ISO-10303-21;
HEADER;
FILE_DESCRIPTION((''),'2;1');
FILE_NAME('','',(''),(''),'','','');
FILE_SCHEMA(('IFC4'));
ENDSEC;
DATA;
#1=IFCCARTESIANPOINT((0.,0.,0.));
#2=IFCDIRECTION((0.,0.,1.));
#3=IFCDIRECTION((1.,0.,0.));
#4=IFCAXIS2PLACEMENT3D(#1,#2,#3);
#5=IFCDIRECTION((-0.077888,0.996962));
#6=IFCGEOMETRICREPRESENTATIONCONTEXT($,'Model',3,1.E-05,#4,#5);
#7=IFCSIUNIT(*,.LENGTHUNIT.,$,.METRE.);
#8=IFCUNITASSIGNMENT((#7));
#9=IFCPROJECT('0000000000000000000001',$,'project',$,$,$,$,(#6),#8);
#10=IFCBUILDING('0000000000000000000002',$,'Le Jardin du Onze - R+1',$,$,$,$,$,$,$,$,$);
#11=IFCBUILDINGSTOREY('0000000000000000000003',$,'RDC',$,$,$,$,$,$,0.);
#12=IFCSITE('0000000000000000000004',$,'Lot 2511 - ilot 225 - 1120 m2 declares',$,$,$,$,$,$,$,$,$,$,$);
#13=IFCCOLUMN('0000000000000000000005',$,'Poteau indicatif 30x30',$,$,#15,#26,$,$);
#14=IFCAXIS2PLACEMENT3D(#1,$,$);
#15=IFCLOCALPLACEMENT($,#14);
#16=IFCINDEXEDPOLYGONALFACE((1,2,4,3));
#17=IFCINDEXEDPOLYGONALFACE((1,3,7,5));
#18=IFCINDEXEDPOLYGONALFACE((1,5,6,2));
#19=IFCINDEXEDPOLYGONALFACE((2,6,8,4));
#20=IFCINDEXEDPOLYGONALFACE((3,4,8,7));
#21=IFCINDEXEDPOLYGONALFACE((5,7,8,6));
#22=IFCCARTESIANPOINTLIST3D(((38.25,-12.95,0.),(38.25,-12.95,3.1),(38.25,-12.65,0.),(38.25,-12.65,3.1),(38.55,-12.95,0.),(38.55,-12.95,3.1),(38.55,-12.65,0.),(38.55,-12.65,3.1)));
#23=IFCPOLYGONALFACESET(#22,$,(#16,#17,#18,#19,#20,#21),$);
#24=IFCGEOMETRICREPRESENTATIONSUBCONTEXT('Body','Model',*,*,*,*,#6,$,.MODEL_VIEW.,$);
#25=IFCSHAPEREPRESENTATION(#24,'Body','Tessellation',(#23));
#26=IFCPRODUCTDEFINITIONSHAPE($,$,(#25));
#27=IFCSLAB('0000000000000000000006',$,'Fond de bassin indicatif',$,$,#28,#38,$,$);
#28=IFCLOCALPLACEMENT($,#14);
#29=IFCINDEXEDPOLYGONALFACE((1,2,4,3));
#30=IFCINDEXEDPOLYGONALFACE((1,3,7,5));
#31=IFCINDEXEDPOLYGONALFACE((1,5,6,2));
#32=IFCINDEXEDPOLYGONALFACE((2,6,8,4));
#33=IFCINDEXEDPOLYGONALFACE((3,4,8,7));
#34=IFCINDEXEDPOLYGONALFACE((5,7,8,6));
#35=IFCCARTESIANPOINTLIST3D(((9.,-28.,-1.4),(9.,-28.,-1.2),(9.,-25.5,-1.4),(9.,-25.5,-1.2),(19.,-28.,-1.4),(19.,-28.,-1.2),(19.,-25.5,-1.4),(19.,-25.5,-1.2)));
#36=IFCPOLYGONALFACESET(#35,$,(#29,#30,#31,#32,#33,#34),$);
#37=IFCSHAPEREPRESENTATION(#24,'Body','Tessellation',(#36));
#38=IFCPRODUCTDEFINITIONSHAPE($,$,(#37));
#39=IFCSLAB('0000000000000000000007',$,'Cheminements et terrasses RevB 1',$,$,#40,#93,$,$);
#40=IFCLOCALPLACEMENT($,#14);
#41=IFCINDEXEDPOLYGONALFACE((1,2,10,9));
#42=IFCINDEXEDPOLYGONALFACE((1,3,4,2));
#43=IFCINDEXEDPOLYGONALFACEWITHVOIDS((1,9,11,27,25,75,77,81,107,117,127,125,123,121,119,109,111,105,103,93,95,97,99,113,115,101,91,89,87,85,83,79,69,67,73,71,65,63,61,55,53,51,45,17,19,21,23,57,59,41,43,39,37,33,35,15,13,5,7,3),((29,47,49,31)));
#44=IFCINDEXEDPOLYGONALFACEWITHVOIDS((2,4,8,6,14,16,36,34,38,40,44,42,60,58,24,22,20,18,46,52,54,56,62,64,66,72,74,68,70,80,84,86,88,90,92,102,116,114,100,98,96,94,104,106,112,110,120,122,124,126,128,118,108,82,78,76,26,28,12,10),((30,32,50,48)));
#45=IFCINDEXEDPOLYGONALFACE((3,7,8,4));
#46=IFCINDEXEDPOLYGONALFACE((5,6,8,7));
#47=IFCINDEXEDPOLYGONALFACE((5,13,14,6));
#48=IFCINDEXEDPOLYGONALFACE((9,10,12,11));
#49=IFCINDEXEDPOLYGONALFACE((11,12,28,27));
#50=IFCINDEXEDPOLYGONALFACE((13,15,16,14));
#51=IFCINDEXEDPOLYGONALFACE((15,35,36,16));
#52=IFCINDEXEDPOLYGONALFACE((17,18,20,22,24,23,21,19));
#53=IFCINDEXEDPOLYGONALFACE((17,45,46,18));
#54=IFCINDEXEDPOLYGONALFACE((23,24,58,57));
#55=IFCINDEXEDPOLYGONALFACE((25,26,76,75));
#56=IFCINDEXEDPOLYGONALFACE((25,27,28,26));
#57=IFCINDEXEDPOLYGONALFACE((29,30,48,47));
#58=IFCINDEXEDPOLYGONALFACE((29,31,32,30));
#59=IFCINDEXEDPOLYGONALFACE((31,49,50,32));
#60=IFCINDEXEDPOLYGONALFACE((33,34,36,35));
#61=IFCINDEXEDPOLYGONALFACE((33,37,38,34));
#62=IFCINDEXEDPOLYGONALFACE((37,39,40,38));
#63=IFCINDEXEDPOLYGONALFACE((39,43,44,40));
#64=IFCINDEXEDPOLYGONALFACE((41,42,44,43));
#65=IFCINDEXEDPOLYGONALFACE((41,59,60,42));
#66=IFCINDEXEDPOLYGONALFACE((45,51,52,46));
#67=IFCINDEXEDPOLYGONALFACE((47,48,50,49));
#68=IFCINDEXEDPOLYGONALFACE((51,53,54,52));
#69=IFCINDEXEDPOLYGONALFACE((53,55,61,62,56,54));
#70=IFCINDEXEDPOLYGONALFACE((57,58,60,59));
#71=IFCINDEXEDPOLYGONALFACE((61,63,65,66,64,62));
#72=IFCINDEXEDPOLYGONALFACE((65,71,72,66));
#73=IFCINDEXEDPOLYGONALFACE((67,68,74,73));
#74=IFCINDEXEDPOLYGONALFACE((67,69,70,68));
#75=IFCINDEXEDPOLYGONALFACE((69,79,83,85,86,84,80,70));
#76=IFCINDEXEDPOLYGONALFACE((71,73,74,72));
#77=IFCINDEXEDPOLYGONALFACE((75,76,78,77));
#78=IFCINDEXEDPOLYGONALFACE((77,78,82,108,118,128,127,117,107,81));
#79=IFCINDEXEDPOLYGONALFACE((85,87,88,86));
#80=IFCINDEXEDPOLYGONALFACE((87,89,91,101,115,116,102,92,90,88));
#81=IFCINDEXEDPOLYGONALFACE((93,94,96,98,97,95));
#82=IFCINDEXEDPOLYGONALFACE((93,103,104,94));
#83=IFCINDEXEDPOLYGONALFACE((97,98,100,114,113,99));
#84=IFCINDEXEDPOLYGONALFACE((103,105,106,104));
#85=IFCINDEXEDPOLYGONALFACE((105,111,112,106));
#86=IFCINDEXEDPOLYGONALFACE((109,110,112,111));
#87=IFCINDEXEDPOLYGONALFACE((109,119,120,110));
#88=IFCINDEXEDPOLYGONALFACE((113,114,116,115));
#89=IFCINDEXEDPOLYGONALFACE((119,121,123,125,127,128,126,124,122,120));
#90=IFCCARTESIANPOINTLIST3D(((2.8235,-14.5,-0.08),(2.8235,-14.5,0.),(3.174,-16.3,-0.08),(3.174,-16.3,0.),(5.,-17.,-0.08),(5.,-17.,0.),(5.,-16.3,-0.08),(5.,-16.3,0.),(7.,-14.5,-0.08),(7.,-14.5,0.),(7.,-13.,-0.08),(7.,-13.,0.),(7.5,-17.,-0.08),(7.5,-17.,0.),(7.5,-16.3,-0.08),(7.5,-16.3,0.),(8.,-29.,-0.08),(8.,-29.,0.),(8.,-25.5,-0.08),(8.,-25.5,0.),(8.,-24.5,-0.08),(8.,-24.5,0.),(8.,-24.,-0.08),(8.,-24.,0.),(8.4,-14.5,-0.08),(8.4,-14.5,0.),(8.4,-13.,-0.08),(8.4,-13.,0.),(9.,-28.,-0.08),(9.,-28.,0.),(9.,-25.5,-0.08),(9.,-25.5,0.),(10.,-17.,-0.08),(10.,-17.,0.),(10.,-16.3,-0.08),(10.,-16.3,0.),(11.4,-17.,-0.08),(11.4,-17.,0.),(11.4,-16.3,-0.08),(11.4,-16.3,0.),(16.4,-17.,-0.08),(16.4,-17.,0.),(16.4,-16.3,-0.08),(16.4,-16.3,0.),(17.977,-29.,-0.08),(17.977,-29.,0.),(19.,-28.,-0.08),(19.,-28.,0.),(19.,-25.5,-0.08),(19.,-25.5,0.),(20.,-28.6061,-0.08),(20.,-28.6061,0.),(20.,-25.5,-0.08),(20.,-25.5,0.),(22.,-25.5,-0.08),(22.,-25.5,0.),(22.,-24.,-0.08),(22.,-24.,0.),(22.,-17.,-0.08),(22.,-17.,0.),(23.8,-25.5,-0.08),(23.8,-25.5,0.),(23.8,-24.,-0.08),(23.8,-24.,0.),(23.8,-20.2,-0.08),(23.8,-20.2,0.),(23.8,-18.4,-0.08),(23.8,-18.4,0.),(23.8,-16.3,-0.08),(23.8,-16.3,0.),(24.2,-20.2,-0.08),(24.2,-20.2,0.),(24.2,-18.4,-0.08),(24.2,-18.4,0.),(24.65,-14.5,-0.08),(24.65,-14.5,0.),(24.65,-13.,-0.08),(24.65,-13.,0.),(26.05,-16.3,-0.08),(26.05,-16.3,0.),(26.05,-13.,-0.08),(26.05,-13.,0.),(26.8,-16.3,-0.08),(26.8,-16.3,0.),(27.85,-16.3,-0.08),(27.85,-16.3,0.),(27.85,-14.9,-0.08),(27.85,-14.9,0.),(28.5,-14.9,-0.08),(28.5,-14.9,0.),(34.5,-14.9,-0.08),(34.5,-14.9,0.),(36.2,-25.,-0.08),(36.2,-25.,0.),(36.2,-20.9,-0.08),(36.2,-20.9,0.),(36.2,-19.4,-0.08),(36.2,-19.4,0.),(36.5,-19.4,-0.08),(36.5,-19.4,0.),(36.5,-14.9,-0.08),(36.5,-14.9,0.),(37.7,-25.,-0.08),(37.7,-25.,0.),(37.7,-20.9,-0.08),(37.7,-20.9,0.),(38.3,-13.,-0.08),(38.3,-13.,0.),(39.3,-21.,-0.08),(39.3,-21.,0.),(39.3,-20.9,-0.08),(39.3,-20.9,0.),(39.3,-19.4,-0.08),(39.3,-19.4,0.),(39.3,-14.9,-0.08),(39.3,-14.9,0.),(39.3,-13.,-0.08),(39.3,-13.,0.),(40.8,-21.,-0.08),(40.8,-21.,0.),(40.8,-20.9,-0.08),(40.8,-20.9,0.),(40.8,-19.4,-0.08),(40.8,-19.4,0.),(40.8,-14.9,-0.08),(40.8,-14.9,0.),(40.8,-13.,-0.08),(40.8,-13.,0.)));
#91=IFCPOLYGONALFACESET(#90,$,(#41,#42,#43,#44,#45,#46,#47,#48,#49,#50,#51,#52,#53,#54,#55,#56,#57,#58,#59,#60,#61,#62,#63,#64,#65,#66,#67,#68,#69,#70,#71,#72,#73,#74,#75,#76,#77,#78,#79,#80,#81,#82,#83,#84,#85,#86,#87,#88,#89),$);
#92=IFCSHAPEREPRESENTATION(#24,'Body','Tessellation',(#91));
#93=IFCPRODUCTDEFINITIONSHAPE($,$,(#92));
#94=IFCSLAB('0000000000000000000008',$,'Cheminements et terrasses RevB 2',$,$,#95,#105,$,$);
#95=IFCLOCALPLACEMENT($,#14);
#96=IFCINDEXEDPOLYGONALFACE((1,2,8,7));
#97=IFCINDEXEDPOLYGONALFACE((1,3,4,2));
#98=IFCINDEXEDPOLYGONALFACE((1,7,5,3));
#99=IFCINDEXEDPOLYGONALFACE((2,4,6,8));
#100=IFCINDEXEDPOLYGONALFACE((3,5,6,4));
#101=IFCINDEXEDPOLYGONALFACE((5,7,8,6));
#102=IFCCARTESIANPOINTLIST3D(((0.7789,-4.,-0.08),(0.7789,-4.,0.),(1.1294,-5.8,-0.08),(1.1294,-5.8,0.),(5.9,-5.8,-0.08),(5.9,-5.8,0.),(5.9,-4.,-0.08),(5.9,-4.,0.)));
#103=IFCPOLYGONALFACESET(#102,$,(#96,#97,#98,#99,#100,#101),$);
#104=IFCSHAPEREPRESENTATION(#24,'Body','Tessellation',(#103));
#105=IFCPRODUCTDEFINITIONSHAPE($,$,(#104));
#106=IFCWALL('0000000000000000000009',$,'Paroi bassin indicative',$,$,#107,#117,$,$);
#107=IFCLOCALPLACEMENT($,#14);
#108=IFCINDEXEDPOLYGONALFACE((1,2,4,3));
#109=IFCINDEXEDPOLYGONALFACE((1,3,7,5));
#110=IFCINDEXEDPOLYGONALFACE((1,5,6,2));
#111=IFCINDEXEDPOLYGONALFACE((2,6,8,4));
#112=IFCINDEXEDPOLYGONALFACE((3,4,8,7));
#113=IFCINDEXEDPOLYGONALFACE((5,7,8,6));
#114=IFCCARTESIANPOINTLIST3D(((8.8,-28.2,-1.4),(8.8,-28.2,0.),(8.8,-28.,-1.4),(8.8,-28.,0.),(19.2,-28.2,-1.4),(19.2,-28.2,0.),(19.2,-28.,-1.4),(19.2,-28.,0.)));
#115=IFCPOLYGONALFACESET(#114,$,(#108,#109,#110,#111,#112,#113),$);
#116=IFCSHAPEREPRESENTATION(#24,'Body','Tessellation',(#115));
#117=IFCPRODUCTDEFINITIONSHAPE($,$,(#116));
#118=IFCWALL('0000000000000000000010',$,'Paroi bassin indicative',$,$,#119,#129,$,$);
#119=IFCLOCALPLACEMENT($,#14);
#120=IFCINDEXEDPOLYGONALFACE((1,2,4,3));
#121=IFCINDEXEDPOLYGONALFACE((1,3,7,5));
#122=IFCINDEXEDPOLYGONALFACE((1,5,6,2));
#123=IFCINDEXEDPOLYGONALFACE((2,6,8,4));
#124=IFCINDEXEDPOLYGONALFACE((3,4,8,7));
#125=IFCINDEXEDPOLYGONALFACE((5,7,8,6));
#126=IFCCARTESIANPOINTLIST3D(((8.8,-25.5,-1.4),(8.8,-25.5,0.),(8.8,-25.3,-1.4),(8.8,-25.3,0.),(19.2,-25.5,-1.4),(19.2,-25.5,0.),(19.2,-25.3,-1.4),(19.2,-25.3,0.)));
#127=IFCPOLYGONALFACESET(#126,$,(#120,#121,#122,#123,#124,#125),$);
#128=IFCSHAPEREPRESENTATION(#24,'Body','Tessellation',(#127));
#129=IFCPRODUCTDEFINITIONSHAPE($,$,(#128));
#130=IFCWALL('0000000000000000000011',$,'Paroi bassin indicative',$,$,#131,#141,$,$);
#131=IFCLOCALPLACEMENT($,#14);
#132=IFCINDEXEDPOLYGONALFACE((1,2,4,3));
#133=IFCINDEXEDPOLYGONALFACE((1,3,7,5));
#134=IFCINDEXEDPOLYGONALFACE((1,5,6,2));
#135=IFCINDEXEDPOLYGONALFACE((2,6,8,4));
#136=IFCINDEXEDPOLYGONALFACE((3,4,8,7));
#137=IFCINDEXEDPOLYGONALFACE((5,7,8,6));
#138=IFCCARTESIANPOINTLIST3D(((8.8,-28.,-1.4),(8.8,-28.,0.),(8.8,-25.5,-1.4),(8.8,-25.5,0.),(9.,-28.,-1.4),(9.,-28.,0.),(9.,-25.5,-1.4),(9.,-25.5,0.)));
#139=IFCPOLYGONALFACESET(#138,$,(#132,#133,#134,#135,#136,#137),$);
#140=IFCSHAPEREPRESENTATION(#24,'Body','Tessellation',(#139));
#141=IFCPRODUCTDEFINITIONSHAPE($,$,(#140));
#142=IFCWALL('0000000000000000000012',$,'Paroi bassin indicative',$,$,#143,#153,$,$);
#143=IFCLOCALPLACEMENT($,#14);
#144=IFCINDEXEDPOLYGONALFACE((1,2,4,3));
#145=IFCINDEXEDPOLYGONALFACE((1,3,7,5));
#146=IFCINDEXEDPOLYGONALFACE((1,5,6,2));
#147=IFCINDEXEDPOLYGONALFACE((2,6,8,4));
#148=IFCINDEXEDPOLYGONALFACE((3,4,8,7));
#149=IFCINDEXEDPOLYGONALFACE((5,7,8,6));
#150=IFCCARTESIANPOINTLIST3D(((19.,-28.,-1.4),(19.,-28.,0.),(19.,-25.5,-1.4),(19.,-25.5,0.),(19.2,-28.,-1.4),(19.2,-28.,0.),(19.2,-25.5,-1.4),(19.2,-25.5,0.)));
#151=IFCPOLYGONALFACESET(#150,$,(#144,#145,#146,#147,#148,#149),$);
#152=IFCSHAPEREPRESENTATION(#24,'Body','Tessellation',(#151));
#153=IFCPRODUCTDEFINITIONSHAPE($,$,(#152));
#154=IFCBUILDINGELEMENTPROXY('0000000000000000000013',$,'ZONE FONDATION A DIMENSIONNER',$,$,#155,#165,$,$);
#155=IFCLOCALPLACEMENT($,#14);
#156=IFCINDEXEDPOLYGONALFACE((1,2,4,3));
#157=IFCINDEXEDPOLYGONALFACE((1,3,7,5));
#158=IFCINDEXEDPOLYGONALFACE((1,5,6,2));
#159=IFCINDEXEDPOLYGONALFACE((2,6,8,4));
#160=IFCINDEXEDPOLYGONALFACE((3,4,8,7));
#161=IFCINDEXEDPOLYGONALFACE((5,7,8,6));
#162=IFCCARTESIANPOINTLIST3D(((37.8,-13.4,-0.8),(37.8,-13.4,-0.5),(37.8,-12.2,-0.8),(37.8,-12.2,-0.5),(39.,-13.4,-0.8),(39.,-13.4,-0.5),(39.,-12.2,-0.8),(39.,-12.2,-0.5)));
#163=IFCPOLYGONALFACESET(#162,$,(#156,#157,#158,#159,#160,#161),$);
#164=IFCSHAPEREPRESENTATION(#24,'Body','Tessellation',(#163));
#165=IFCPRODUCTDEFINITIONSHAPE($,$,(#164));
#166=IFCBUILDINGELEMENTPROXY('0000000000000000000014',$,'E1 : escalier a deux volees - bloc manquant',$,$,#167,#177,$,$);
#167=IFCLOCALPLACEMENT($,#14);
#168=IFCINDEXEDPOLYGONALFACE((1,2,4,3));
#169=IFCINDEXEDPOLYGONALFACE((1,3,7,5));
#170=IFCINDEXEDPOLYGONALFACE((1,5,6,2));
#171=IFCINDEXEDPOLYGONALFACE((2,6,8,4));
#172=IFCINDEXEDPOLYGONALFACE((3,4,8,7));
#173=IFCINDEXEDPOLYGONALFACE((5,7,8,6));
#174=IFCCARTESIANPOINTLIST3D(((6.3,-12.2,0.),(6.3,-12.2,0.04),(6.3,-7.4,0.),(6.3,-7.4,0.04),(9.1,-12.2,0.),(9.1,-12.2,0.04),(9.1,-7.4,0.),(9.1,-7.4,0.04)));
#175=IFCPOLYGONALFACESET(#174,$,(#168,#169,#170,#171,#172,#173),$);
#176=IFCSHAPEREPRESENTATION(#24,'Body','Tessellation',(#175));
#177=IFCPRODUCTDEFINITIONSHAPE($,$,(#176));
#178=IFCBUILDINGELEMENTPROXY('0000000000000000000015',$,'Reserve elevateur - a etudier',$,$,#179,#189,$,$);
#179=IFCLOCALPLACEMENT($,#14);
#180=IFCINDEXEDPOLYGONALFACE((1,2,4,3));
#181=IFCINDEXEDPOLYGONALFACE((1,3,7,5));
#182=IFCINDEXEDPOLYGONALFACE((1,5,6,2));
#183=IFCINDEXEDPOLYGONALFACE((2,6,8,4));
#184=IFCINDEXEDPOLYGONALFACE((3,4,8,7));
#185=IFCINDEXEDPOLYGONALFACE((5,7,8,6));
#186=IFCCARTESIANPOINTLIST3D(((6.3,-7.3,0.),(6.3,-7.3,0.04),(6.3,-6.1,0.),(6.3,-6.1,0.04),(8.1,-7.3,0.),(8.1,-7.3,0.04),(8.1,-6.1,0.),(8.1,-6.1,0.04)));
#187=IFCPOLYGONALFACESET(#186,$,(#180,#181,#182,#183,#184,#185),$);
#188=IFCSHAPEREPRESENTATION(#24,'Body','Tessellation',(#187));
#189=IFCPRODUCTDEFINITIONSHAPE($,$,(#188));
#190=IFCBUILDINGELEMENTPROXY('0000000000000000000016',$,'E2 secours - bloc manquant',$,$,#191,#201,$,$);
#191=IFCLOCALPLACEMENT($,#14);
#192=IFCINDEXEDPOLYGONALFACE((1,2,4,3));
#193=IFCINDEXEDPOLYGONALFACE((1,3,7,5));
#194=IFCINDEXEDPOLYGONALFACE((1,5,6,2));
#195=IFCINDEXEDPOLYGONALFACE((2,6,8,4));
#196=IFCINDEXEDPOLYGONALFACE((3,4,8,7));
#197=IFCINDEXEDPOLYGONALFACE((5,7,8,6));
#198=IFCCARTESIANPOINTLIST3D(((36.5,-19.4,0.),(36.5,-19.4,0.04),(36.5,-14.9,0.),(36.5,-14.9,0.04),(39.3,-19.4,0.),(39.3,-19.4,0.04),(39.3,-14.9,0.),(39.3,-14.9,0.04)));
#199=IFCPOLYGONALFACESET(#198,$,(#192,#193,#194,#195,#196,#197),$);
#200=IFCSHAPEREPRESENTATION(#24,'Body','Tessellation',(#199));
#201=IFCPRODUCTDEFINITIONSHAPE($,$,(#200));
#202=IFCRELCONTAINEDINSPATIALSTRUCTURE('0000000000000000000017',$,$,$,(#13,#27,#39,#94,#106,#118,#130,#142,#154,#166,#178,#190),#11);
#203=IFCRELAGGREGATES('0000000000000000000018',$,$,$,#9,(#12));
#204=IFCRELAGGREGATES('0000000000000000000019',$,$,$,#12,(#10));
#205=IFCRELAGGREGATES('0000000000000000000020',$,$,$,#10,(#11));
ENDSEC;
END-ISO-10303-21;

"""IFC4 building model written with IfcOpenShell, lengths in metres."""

from ifc_helpers import new_model, si_unit, direction, frame, origin, origin_with_axes, place, context, subcontext, project, spatial, polyline, outline, extrude, element, save


model = new_model("IFC4")

# Units and contexts
model_context = context("Model", 3, precision=1e-05, world=origin_with_axes(), true_north=direction((-0.077888, 0.996962)))
body_context = subcontext(model_context, "Body", "Model", "MODEL_VIEW")
ifc_project = project(units=[si_unit("LENGTHUNIT", "METRE")], contexts=[model_context])

# Site, building, storey
site = spatial("IfcSite", under=ifc_project, Name="Lot 2511 - ilot 225 - 1120 m2 declares")
building = spatial("IfcBuilding", under=site, Name="Le Jardin du Onze - R+1")
storey = spatial("IfcBuildingStorey", under=building, Name="RDC", Elevation=0.0)

# Column
column_placement = place(None, origin_with_axes())
element("IfcColumn", 1, at=column_placement, inside=storey, Name="Poteau indicatif 30x30", context=body_context, shape_type="SweptSolid", body=[
    extrude(outline(polyline([(38.55, -12.95), (38.55, -12.65), (38.25, -12.65), (38.25, -12.95), (38.55, -12.95)])), origin(), (0.0, 0.0, 1.0), 3.1),
])

# Slabs
slab_1_placement = place(None, origin_with_axes())
element("IfcSlab", 2, at=slab_1_placement, inside=storey, Name="Fond de bassin indicatif", context=body_context, shape_type="SweptSolid", body=[
    extrude(outline(polyline([(19.0, -28.0), (19.0, -25.5), (9.0, -25.5), (9.0, -28.0), (19.0, -28.0)])), frame((0.0, 0.0, -1.4)), (0.0, 0.0, 1.0), 0.2),
])
slab_2_placement = place(None, origin_with_axes())
element("IfcSlab", 3, at=slab_2_placement, inside=storey, Name="Cheminements et terrasses RevB 1", context=body_context, shape_type="SweptSolid", body=[
    extrude(outline(polyline([(8.0, -29.0), (8.0, -25.5), (8.0, -24.5), (8.0, -24.0), (22.0, -24.0), (22.0, -17.0), (16.4, -17.0), (16.4, -16.3), (11.4, -16.3), (11.4, -17.0), (10.0, -17.0), (10.0, -16.3), (7.5, -16.3), (7.5, -17.0), (5.0, -17.0), (5.0, -16.3), (3.174, -16.3), (2.8235, -14.5), (7.0, -14.5), (7.0, -13.0), (8.4, -13.0), (8.4, -14.5), (24.65, -14.5), (24.65, -13.0), (26.05, -13.0), (26.05, -14.5), (26.05, -14.5), (26.05, -13.0), (38.3, -13.0), (39.3, -13.0), (40.8, -13.0), (40.8, -14.9), (40.8, -19.4), (40.8, -19.4), (40.8, -20.9), (40.8, -20.9), (40.8, -21.0), (39.3, -21.0), (39.3, -20.9), (37.7, -20.9), (37.7, -25.0), (36.2, -25.0), (36.2, -20.9), (36.2, -19.4), (36.5, -19.4), (39.3, -19.4), (39.3, -14.9), (36.5, -14.9), (34.5, -14.9), (28.5, -14.9), (27.85, -14.9), (27.85, -16.3), (26.8, -16.3), (26.05, -16.3), (23.8, -16.3), (23.8, -18.4), (24.2, -18.4), (24.2, -20.2), (23.8, -20.2), (23.8, -24.0), (23.8, -25.5), (22.0, -25.5), (20.0, -25.5), (20.0, -28.6061), (17.977, -29.0), (8.0, -29.0)]), holes=[polyline([(9.0, -25.5), (9.0, -28.0), (19.0, -28.0), (19.0, -25.5), (9.0, -25.5)])]), frame((0.0, 0.0, -0.08)), (0.0, 0.0, 1.0), 0.08),
])
slab_3_placement = place(None, origin_with_axes())
element("IfcSlab", 4, at=slab_3_placement, inside=storey, Name="Cheminements et terrasses RevB 2", context=body_context, shape_type="SweptSolid", body=[
    extrude(outline(polyline([(5.9, -4.0), (5.9, -5.8), (1.1294, -5.8), (0.7789, -4.0), (5.9, -4.0)])), frame((0.0, 0.0, -0.08)), (0.0, 0.0, 1.0), 0.08),
])

# Walls
wall_1_placement = place(None, origin_with_axes())
element("IfcWall", 5, at=wall_1_placement, inside=storey, Name="Paroi bassin indicative", context=body_context, shape_type="SweptSolid", body=[
    extrude(outline(polyline([(19.2, -28.2), (19.2, -28.0), (8.8, -28.0), (8.8, -28.2), (19.2, -28.2)])), frame((0.0, 0.0, -1.4)), (0.0, 0.0, 1.0), 1.4),
])
wall_2_placement = place(None, origin_with_axes())
element("IfcWall", 6, at=wall_2_placement, inside=storey, Name="Paroi bassin indicative", context=body_context, shape_type="SweptSolid", body=[
    extrude(outline(polyline([(19.2, -25.5), (19.2, -25.3), (8.8, -25.3), (8.8, -25.5), (19.2, -25.5)])), frame((0.0, 0.0, -1.4)), (0.0, 0.0, 1.0), 1.4),
])
wall_3_placement = place(None, origin_with_axes())
element("IfcWall", 7, at=wall_3_placement, inside=storey, Name="Paroi bassin indicative", context=body_context, shape_type="SweptSolid", body=[
    extrude(outline(polyline([(9.0, -28.0), (9.0, -25.5), (8.8, -25.5), (8.8, -28.0), (9.0, -28.0)])), frame((0.0, 0.0, -1.4)), (0.0, 0.0, 1.0), 1.4),
])
wall_4_placement = place(None, origin_with_axes())
element("IfcWall", 8, at=wall_4_placement, inside=storey, Name="Paroi bassin indicative", context=body_context, shape_type="SweptSolid", body=[
    extrude(outline(polyline([(19.2, -28.0), (19.2, -25.5), (19.0, -25.5), (19.0, -28.0), (19.2, -28.0)])), frame((0.0, 0.0, -1.4)), (0.0, 0.0, 1.0), 1.4),
])

# Building element proxies
proxy_1_placement = place(None, origin_with_axes())
element("IfcBuildingElementProxy", 9, at=proxy_1_placement, inside=storey, Name="ZONE FONDATION A DIMENSIONNER", context=body_context, shape_type="SweptSolid", body=[
    extrude(outline(polyline([(39.0, -13.4), (39.0, -12.2), (37.8, -12.2), (37.8, -13.4), (39.0, -13.4)])), frame((0.0, 0.0, -0.8)), (0.0, 0.0, 1.0), 0.3),
])
proxy_2_placement = place(None, origin_with_axes())
element("IfcBuildingElementProxy", 10, at=proxy_2_placement, inside=storey, Name="E1 : escalier a deux volees - bloc manquant", context=body_context, shape_type="SweptSolid", body=[
    extrude(outline(polyline([(9.1, -12.2), (9.1, -7.4), (6.3, -7.4), (6.3, -12.2), (9.1, -12.2)])), origin(), (0.0, 0.0, 1.0), 0.04),
])
proxy_3_placement = place(None, origin_with_axes())
element("IfcBuildingElementProxy", 11, at=proxy_3_placement, inside=storey, Name="Reserve elevateur - a etudier", context=body_context, shape_type="SweptSolid", body=[
    extrude(outline(polyline([(8.1, -7.3), (8.1, -6.1), (6.3, -6.1), (6.3, -7.3), (8.1, -7.3)])), origin(), (0.0, 0.0, 1.0), 0.04),
])
proxy_4_placement = place(None, origin_with_axes())
element("IfcBuildingElementProxy", 12, at=proxy_4_placement, inside=storey, Name="E2 secours - bloc manquant", context=body_context, shape_type="SweptSolid", body=[
    extrude(outline(polyline([(39.3, -19.4), (39.3, -14.9), (36.5, -14.9), (36.5, -19.4), (39.3, -19.4)])), origin(), (0.0, 0.0, 1.0), 0.04),
])

save(model, "model.ifc")
